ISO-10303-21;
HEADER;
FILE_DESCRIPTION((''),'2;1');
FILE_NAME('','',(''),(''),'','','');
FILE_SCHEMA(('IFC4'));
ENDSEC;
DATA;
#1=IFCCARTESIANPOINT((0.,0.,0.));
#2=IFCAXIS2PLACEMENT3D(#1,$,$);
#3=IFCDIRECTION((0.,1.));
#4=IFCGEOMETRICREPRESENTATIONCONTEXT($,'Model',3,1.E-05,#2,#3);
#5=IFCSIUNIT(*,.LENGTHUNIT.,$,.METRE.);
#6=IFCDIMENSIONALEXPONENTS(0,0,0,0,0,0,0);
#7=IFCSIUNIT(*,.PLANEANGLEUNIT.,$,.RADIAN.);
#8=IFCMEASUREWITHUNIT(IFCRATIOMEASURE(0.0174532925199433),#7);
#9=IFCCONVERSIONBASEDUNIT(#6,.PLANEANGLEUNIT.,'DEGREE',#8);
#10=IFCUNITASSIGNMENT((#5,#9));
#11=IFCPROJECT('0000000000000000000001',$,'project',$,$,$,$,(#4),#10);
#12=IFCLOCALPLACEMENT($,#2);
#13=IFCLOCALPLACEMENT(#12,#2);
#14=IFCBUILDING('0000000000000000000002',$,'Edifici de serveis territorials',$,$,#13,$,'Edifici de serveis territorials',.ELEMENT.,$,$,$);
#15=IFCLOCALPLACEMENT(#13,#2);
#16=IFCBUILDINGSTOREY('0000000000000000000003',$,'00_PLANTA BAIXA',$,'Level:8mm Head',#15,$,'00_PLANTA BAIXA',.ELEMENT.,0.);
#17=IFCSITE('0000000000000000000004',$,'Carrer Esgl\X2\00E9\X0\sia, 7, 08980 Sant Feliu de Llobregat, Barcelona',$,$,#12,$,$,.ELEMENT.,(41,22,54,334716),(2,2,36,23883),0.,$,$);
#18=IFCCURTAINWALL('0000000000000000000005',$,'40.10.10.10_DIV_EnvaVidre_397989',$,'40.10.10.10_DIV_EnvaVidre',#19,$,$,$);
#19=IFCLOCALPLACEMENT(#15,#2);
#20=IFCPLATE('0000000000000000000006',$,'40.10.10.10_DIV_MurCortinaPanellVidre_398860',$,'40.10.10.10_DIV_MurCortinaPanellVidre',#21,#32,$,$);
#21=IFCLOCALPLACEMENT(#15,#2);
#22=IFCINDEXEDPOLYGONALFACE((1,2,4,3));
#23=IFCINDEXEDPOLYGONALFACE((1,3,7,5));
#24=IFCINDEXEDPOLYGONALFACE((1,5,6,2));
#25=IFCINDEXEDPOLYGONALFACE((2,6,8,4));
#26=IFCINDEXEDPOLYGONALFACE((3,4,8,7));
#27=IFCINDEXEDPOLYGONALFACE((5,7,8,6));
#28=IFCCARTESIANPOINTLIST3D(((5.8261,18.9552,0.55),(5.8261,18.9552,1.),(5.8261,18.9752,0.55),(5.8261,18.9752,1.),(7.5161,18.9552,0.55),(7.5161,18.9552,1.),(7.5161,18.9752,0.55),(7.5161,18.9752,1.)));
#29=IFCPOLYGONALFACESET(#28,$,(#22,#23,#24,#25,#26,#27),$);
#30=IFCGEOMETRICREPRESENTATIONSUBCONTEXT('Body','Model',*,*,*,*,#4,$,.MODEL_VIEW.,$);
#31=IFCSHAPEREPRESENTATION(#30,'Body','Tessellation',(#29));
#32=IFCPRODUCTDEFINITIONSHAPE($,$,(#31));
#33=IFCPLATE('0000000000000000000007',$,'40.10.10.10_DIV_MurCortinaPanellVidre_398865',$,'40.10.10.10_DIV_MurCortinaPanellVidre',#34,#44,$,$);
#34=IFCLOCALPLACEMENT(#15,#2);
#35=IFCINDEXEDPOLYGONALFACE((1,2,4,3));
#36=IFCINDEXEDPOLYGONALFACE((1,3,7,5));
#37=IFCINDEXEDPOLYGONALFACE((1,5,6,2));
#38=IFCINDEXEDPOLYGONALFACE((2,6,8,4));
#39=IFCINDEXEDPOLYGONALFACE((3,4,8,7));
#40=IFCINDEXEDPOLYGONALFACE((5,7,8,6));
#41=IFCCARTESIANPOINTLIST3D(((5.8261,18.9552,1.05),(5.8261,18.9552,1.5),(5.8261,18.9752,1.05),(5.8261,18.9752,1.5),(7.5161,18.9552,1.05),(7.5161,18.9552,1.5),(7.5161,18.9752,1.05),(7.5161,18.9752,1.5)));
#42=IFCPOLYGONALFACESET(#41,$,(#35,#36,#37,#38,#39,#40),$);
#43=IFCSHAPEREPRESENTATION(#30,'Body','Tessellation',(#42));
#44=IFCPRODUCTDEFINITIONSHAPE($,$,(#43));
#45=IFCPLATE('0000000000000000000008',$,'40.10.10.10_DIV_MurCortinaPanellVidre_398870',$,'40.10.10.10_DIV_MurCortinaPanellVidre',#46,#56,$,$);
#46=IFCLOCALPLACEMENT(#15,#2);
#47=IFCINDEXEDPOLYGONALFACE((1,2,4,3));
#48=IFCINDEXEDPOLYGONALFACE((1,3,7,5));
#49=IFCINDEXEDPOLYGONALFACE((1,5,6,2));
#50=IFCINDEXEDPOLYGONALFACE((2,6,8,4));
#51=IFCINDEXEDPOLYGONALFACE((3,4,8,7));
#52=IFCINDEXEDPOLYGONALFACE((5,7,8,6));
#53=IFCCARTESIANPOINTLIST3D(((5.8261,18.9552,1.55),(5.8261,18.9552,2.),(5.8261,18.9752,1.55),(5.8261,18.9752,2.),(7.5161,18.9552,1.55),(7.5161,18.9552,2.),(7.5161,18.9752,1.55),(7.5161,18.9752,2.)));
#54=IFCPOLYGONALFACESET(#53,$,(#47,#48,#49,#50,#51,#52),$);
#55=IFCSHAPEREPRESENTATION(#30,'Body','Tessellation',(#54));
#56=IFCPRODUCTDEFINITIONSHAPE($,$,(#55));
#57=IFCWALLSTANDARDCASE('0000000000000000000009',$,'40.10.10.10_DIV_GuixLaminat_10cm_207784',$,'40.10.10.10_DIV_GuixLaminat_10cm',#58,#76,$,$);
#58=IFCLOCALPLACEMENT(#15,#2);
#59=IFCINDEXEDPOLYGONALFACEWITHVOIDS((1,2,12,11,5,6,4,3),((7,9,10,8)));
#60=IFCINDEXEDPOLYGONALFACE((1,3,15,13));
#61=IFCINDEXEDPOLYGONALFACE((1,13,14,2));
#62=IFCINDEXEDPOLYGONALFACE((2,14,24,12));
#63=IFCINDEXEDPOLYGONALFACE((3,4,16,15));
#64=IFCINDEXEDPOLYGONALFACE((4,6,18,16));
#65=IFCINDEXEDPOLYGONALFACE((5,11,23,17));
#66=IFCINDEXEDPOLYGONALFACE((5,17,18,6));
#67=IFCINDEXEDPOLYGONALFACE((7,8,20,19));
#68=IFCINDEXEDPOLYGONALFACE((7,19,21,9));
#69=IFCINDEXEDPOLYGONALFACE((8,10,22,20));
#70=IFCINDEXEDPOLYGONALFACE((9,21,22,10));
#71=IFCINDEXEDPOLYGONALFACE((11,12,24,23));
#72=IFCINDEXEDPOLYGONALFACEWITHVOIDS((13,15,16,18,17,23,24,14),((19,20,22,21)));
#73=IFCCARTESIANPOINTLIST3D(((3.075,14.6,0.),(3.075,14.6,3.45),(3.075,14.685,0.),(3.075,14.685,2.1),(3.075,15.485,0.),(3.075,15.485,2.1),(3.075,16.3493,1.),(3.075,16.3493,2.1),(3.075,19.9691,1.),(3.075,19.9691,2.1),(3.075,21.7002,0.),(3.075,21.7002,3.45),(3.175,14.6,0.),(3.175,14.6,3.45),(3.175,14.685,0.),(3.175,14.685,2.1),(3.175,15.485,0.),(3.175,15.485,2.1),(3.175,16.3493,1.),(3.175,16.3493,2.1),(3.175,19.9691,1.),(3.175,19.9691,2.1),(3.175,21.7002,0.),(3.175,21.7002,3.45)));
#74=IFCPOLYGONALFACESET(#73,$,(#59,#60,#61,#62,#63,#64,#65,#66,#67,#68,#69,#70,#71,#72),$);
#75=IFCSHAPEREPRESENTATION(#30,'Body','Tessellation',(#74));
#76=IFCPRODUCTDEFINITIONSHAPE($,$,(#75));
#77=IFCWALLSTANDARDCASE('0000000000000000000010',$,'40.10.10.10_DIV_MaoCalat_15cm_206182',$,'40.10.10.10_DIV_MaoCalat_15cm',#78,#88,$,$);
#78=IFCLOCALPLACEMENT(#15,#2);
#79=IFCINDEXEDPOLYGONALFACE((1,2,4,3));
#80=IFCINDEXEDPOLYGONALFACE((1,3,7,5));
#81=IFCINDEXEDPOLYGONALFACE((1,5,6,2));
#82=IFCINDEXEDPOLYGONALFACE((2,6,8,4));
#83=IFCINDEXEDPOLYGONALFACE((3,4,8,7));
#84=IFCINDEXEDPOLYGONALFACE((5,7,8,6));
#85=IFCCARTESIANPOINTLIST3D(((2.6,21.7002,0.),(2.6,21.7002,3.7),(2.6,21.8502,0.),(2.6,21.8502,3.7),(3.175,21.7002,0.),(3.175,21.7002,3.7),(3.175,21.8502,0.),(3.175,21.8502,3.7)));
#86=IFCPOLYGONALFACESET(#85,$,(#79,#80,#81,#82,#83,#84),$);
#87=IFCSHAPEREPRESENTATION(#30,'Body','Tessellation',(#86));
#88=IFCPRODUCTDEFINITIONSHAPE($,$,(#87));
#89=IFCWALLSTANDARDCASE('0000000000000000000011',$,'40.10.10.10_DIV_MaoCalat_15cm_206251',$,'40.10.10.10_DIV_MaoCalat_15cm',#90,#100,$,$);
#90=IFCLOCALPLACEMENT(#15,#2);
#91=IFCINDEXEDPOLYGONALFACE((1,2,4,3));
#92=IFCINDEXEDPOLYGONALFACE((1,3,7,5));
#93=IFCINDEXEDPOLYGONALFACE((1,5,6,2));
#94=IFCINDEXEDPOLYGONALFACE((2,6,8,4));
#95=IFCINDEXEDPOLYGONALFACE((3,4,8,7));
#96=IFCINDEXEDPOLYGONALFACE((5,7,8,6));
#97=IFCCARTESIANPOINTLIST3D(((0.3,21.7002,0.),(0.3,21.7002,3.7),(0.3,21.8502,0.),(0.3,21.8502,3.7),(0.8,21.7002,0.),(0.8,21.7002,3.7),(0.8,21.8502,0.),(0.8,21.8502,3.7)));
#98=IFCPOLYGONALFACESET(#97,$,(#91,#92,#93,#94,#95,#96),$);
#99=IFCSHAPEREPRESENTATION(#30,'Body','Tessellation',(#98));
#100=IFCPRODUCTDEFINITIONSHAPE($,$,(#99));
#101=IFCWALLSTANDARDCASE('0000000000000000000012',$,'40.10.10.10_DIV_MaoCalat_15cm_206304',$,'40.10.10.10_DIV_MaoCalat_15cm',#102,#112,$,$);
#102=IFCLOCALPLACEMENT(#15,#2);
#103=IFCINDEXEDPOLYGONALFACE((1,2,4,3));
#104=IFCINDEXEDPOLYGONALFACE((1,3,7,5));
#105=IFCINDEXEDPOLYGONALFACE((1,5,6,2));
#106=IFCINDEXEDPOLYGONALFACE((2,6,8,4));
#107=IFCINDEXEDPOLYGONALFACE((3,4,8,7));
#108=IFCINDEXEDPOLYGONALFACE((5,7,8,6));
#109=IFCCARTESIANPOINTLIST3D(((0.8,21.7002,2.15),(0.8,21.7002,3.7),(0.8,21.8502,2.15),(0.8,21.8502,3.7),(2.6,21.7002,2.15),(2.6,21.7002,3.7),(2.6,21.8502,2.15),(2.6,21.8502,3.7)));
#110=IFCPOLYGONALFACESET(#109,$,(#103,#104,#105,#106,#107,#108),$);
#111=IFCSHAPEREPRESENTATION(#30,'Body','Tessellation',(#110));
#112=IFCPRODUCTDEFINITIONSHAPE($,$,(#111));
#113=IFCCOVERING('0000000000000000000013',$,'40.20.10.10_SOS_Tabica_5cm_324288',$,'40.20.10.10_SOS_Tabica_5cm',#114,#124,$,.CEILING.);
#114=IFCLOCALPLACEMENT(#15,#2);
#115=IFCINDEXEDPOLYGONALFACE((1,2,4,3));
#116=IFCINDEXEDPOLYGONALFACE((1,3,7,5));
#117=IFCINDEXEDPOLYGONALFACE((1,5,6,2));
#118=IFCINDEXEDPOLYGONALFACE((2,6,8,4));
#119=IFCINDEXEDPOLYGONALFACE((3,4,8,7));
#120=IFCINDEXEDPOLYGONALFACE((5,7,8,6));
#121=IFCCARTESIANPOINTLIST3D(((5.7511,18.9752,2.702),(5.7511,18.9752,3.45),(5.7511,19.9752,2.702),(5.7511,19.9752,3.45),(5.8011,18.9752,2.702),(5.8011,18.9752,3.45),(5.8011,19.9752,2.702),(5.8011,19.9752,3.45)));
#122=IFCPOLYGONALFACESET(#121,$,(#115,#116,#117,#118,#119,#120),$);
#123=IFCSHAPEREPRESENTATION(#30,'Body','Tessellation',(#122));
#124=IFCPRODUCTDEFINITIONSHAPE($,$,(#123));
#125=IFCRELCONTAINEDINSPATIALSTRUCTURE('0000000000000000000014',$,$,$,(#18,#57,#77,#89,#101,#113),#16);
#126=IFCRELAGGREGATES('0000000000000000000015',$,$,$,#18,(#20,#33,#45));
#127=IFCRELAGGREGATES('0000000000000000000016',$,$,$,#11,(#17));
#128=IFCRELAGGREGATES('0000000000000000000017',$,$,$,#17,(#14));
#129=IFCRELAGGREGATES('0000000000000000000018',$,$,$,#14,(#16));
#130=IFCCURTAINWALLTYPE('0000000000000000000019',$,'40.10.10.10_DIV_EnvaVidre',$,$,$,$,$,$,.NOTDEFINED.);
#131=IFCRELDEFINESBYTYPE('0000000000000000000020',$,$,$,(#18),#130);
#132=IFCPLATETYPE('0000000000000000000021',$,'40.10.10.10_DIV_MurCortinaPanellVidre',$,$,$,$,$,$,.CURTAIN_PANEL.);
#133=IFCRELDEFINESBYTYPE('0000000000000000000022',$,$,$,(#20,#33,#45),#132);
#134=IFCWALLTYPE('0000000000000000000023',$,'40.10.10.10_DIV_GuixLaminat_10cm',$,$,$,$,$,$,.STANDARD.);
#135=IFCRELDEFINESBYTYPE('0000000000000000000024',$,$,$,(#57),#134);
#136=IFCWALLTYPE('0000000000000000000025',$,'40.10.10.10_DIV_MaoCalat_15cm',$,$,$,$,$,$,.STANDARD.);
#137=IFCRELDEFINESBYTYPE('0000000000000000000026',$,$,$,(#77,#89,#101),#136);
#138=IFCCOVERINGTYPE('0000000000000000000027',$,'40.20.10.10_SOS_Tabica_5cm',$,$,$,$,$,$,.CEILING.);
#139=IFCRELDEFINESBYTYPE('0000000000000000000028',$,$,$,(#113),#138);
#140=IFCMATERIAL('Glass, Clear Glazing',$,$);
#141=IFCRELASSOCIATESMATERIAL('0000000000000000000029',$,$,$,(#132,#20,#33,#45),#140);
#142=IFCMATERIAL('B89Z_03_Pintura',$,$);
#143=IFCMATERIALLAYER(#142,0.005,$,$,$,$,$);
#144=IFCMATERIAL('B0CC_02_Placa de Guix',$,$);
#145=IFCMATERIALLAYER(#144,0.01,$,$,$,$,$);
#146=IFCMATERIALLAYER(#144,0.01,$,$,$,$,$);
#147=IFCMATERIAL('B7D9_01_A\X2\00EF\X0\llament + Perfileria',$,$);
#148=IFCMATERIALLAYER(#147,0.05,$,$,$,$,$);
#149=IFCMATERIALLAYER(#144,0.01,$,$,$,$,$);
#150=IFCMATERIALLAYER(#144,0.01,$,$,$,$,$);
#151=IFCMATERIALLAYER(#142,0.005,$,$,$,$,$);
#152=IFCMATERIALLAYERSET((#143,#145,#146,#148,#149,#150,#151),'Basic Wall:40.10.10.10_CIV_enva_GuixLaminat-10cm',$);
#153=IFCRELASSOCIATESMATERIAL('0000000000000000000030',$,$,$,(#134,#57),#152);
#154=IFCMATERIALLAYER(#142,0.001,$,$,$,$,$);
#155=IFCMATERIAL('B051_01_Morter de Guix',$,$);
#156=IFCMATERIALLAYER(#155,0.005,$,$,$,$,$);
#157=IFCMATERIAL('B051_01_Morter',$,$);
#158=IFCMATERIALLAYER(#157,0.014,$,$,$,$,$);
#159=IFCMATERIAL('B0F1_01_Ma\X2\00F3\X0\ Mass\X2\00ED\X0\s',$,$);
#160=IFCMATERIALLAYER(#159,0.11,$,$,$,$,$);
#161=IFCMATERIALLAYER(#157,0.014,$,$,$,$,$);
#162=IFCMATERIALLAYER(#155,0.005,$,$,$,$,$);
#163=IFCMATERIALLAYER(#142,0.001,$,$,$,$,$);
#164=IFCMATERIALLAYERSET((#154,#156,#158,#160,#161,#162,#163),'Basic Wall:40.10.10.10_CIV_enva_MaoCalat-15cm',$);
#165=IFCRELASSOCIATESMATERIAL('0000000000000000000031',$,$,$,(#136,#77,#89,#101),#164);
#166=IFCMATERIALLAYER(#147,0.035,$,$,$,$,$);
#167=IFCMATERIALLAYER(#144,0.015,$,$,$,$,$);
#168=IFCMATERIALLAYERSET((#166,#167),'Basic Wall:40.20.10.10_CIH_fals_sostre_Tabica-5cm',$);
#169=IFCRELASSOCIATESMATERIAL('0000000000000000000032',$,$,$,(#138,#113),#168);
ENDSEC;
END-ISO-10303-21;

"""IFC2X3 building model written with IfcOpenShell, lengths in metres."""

from ifc_helpers import new_model, entity, si_unit, converted_unit, direction, frame, frame_2d, origin, place, context, subcontext, project, spatial, polyline, rectangle, extrude, clip, bounded_halfspace, source, transform, mapped, material, layer, layer_set, layer_usage, type_object, type_shapes, element, aggregate, save


model = new_model("IFC2X3")

# Units and contexts
model_context = context("Model", 3, precision=1e-05, world=origin(), true_north=direction((0.0, 1.0)))
body_context = subcontext(model_context, "Body", "Model", "MODEL_VIEW")
ifc_project = project(units=[si_unit("LENGTHUNIT", "METRE"), converted_unit("PLANEANGLEUNIT", "DEGREE", entity("IfcRatioMeasure", 0.0174532925199433), si_unit("PLANEANGLEUNIT", "RADIAN"), dimensions=[0, 0, 0, 0, 0, 0, 0])], contexts=[model_context])

# Site, building, storey
site_placement = place(None, origin())
site = spatial("IfcSite", under=ifc_project, at=site_placement, Name="Carrer Església, 7, 08980 Sant Feliu de Llobregat, Barcelona", CompositionType="ELEMENT", RefLatitude=(41, 22, 54, 334716), RefLongitude=(2, 2, 36, 23883), RefElevation=0.0)
building_placement = place(site_placement, origin())
building = spatial("IfcBuilding", under=site, at=building_placement, Name="Edifici de serveis territorials", LongName="Edifici de serveis territorials", CompositionType="ELEMENT")
storey_placement = place(building_placement, origin())
storey = spatial("IfcBuildingStorey", under=building, at=storey_placement, Name="00_PLANTA BAIXA", ObjectType="Level:8mm Head", LongName="00_PLANTA BAIXA", CompositionType="ELEMENT", Elevation=0.0)

# Curtain wall, plates
curtain_wall_type = type_object("IfcCurtainWallType", Name="40.10.10.10_DIV_EnvaVidre", PredefinedType="NOTDEFINED")
curtain_wall_placement = place(storey_placement, origin())
curtain_wall = element("IfcCurtainWall", 1, at=curtain_wall_placement, inside=storey, type_object=curtain_wall_type, Name="40.10.10.10_DIV_EnvaVidre_397989", ObjectType="40.10.10.10_DIV_EnvaVidre")
ifc_material_1 = material(Name="Glass, Clear Glazing")
plate_type = type_object("IfcPlateType", Name="40.10.10.10_DIV_MurCortinaPanellVidre", PredefinedType="CURTAIN_PANEL", material=ifc_material_1)
shared_shape_1 = source(origin(), body_context, "Body", "SweptSolid", [
    extrude(rectangle(XDim=0.02, YDim=1.69, at=frame_2d((0.0, 0.0), x_axis=(1.0, 0.0))), frame((0.845, 0.01, 0.0), z_axis=(0.0, 0.0, 1.0), x_axis=(0.0, 1.0, 0.0)), (0.0, 0.0, 1.0), 0.45),
])
type_shapes(plate_type, [shared_shape_1])
plate_1_placement = place(curtain_wall_placement, frame((5.8261, 18.9552, 0.55)))
plate_1 = element("IfcPlate", 2, at=plate_1_placement, type_object=plate_type, material=ifc_material_1, Name="40.10.10.10_DIV_MurCortinaPanellVidre_398860", ObjectType="40.10.10.10_DIV_MurCortinaPanellVidre", context=body_context, shape_type="MappedRepresentation", body=[
    mapped(shared_shape_1, transform((0.0, 0.0, 0.0), scale=1.0)),
])
plate_2_placement = place(curtain_wall_placement, frame((5.8261, 18.9552, 1.05)))
plate_2 = element("IfcPlate", 3, at=plate_2_placement, type_object=plate_type, material=ifc_material_1, Name="40.10.10.10_DIV_MurCortinaPanellVidre_398865", ObjectType="40.10.10.10_DIV_MurCortinaPanellVidre", context=body_context, shape_type="MappedRepresentation", body=[
    mapped(shared_shape_1, transform((0.0, 0.0, 0.0), scale=1.0)),
])
plate_3_placement = place(curtain_wall_placement, frame((5.8261, 18.9552, 1.55)))
plate_3 = element("IfcPlate", 4, at=plate_3_placement, type_object=plate_type, material=ifc_material_1, Name="40.10.10.10_DIV_MurCortinaPanellVidre_398870", ObjectType="40.10.10.10_DIV_MurCortinaPanellVidre", context=body_context, shape_type="MappedRepresentation", body=[
    mapped(shared_shape_1, transform((0.0, 0.0, 0.0), scale=1.0)),
])
aggregate(curtain_wall, [plate_1, plate_2, plate_3])

# Wall, openings
ifc_material_2 = material(Name="B89Z_03_Pintura")
ifc_layer_1 = layer(ifc_material_2, 0.005)
ifc_material_3 = material(Name="B0CC_02_Placa de Guix")
ifc_layer_2 = layer(ifc_material_3, 0.01)
ifc_layer_3 = layer(ifc_material_3, 0.01)
ifc_material_4 = material(Name="B7D9_01_Aïllament + Perfileria")
ifc_layer_4 = layer(ifc_material_4, 0.05)
ifc_layer_5 = layer(ifc_material_3, 0.01)
ifc_layer_6 = layer(ifc_material_3, 0.01)
ifc_layer_7 = layer(ifc_material_2, 0.005)
ifc_layer_set_1 = layer_set([ifc_layer_1, ifc_layer_2, ifc_layer_3, ifc_layer_4, ifc_layer_5, ifc_layer_6, ifc_layer_7], Name="Basic Wall:40.10.10.10_CIV_enva_GuixLaminat-10cm")
ifc_layer_usage_1 = layer_usage(ifc_layer_set_1, "AXIS2", "NEGATIVE", 0.05)
wall_type_1 = type_object("IfcWallType", Name="40.10.10.10_DIV_GuixLaminat_10cm", PredefinedType="STANDARD", material=ifc_layer_set_1)
wall_1_placement = place(storey_placement, frame((3.125, 21.7002, 0.0), z_axis=(0.0, 0.0, 1.0), x_axis=(0.0, -1.0, 0.0)))
wall_1 = element("IfcWallStandardCase", 5, at=wall_1_placement, inside=storey, type_object=wall_type_1, material=ifc_layer_usage_1, Name="40.10.10.10_DIV_GuixLaminat_10cm_207784", ObjectType="40.10.10.10_DIV_GuixLaminat_10cm", context=body_context, shape_type="Clipping", body=[
    clip(extrude(rectangle(XDim=7.1002, YDim=0.1, at=frame_2d((3.5501, 0.0), x_axis=(-1.0, 0.0))), origin(), (0.0, 0.0, 1.0), 3.45), bounded_halfspace(frame((0.0, -0.05, 3.45), z_axis=(0.0, 0.0, -1.0), x_axis=(0.999675, 0.025497, 0.0)), True, frame((0.0, -0.05, 3.45)), polyline([(0.0, 0.0), (7.1002, 0.0), (7.1002, 0.1), (0.0, 0.1), (0.0, 0.0)]))),
])
opening_1_placement = place(wall_1_placement, origin())
element("IfcOpeningElement", 6, at=opening_1_placement, cuts=wall_1, ObjectType="Opening", context=body_context, shape_type="SweptSolid", body=[
    extrude(rectangle(XDim=1.1, YDim=3.6199, at=frame_2d((0.0, 0.0), x_axis=(1.0, 0.0))), frame((3.541, 0.05, 1.55), z_axis=(0.0, -1.0, 0.0), x_axis=(0.0, 0.0, -1.0)), (0.0, 0.0, 1.0), 0.1),
])
opening_2_placement = place(wall_1_placement, frame((7.0152, 0.05, 0.0)))
element("IfcOpeningElement", 7, at=opening_2_placement, cuts=wall_1, ObjectType="Opening", context=body_context, shape_type="SweptSolid", body=[
    extrude(rectangle(XDim=2.1, YDim=0.8, at=frame_2d((1.05, 0.4), x_axis=(1.0, 0.0))), frame((0.0, 0.0, 0.0), z_axis=(0.0, -1.0, 0.0), x_axis=(0.0, 0.0, 1.0)), (0.0, 0.0, 1.0), 0.1),
])
opening_3_placement = place(wall_1_placement, frame((0.8852, 0.15, 0.0)))
element("IfcOpeningElement", 8, at=opening_3_placement, cuts=wall_1, ObjectType="Opening", context=body_context, shape_type="SweptSolid", body=[
    extrude(rectangle(XDim=2.1, YDim=0.8, at=frame_2d((1.05, 0.4), x_axis=(1.0, 0.0))), frame((0.0, 0.0, 0.0), z_axis=(0.0, -1.0, 0.0), x_axis=(0.0, 0.0, 1.0)), (0.0, 0.0, 1.0), 0.1),
])

# Walls
ifc_layer_8 = layer(ifc_material_2, 0.001)
ifc_material_5 = material(Name="B051_01_Morter de Guix")
ifc_layer_9 = layer(ifc_material_5, 0.005)
ifc_material_6 = material(Name="B051_01_Morter")
ifc_layer_10 = layer(ifc_material_6, 0.014)
ifc_material_7 = material(Name="B0F1_01_Maó Massís")
ifc_layer_11 = layer(ifc_material_7, 0.11)
ifc_layer_12 = layer(ifc_material_6, 0.014)
ifc_layer_13 = layer(ifc_material_5, 0.005)
ifc_layer_14 = layer(ifc_material_2, 0.001)
ifc_layer_set_2 = layer_set([ifc_layer_8, ifc_layer_9, ifc_layer_10, ifc_layer_11, ifc_layer_12, ifc_layer_13, ifc_layer_14], Name="Basic Wall:40.10.10.10_CIV_enva_MaoCalat-15cm")
ifc_layer_usage_2 = layer_usage(ifc_layer_set_2, "AXIS2", "NEGATIVE", 0.075)
wall_type_2 = type_object("IfcWallType", Name="40.10.10.10_DIV_MaoCalat_15cm", PredefinedType="STANDARD", material=ifc_layer_set_2)
wall_2_placement = place(storey_placement, frame((2.6, 21.7752, 0.0)))
element("IfcWallStandardCase", 9, at=wall_2_placement, inside=storey, type_object=wall_type_2, material=ifc_layer_usage_2, Name="40.10.10.10_DIV_MaoCalat_15cm_206182", ObjectType="40.10.10.10_DIV_MaoCalat_15cm", context=body_context, shape_type="SweptSolid", body=[
    extrude(rectangle(XDim=0.575, YDim=0.15, at=frame_2d((0.2875, 0.0), x_axis=(-1.0, 0.0))), origin(), (0.0, 0.0, 1.0), 3.7),
])
ifc_layer_usage_3 = layer_usage(ifc_layer_set_2, "AXIS2", "NEGATIVE", 0.075)
wall_3_placement = place(storey_placement, frame((0.8, 21.7752, 0.0), z_axis=(0.0, 0.0, 1.0), x_axis=(-1.0, 0.0, 0.0)))
element("IfcWallStandardCase", 10, at=wall_3_placement, inside=storey, type_object=wall_type_2, material=ifc_layer_usage_3, Name="40.10.10.10_DIV_MaoCalat_15cm_206251", ObjectType="40.10.10.10_DIV_MaoCalat_15cm", context=body_context, shape_type="SweptSolid", body=[
    extrude(rectangle(XDim=0.5, YDim=0.15, at=frame_2d((0.25, 0.0), x_axis=(-1.0, 0.0))), origin(), (0.0, 0.0, 1.0), 3.7),
])
ifc_layer_usage_4 = layer_usage(ifc_layer_set_2, "AXIS2", "NEGATIVE", 0.075)
wall_4_placement = place(storey_placement, frame((0.8, 21.7752, 2.15)))
element("IfcWallStandardCase", 11, at=wall_4_placement, inside=storey, type_object=wall_type_2, material=ifc_layer_usage_4, Name="40.10.10.10_DIV_MaoCalat_15cm_206304", ObjectType="40.10.10.10_DIV_MaoCalat_15cm", context=body_context, shape_type="SweptSolid", body=[
    extrude(rectangle(XDim=1.8, YDim=0.15, at=frame_2d((0.9, 0.0), x_axis=(-1.0, 0.0))), origin(), (0.0, 0.0, 1.0), 1.55),
])

# Covering
ifc_layer_15 = layer(ifc_material_4, 0.035)
ifc_layer_16 = layer(ifc_material_3, 0.015)
ifc_layer_set_3 = layer_set([ifc_layer_15, ifc_layer_16], Name="Basic Wall:40.20.10.10_CIH_fals_sostre_Tabica-5cm")
ifc_layer_usage_5 = layer_usage(ifc_layer_set_3, "AXIS2", "POSITIVE", -0.025)
covering_type = type_object("IfcCoveringType", Name="40.20.10.10_SOS_Tabica_5cm", PredefinedType="CEILING", material=ifc_layer_set_3)
covering_placement = place(storey_placement, frame((5.7761, 19.9752, 2.702), z_axis=(0.0, 0.0, 1.0), x_axis=(0.0, -1.0, 0.0)))
element("IfcCovering", 12, at=covering_placement, inside=storey, type_object=covering_type, material=ifc_layer_usage_5, Name="40.20.10.10_SOS_Tabica_5cm_324288", ObjectType="40.20.10.10_SOS_Tabica_5cm", PredefinedType="CEILING", context=body_context, shape_type="SweptSolid", body=[
    extrude(rectangle(XDim=1.0, YDim=0.05, at=frame_2d((0.5, 0.0), x_axis=(-1.0, 0.0))), origin(), (0.0, 0.0, 1.0), 0.748),
])

save(model, "model.ifc")
